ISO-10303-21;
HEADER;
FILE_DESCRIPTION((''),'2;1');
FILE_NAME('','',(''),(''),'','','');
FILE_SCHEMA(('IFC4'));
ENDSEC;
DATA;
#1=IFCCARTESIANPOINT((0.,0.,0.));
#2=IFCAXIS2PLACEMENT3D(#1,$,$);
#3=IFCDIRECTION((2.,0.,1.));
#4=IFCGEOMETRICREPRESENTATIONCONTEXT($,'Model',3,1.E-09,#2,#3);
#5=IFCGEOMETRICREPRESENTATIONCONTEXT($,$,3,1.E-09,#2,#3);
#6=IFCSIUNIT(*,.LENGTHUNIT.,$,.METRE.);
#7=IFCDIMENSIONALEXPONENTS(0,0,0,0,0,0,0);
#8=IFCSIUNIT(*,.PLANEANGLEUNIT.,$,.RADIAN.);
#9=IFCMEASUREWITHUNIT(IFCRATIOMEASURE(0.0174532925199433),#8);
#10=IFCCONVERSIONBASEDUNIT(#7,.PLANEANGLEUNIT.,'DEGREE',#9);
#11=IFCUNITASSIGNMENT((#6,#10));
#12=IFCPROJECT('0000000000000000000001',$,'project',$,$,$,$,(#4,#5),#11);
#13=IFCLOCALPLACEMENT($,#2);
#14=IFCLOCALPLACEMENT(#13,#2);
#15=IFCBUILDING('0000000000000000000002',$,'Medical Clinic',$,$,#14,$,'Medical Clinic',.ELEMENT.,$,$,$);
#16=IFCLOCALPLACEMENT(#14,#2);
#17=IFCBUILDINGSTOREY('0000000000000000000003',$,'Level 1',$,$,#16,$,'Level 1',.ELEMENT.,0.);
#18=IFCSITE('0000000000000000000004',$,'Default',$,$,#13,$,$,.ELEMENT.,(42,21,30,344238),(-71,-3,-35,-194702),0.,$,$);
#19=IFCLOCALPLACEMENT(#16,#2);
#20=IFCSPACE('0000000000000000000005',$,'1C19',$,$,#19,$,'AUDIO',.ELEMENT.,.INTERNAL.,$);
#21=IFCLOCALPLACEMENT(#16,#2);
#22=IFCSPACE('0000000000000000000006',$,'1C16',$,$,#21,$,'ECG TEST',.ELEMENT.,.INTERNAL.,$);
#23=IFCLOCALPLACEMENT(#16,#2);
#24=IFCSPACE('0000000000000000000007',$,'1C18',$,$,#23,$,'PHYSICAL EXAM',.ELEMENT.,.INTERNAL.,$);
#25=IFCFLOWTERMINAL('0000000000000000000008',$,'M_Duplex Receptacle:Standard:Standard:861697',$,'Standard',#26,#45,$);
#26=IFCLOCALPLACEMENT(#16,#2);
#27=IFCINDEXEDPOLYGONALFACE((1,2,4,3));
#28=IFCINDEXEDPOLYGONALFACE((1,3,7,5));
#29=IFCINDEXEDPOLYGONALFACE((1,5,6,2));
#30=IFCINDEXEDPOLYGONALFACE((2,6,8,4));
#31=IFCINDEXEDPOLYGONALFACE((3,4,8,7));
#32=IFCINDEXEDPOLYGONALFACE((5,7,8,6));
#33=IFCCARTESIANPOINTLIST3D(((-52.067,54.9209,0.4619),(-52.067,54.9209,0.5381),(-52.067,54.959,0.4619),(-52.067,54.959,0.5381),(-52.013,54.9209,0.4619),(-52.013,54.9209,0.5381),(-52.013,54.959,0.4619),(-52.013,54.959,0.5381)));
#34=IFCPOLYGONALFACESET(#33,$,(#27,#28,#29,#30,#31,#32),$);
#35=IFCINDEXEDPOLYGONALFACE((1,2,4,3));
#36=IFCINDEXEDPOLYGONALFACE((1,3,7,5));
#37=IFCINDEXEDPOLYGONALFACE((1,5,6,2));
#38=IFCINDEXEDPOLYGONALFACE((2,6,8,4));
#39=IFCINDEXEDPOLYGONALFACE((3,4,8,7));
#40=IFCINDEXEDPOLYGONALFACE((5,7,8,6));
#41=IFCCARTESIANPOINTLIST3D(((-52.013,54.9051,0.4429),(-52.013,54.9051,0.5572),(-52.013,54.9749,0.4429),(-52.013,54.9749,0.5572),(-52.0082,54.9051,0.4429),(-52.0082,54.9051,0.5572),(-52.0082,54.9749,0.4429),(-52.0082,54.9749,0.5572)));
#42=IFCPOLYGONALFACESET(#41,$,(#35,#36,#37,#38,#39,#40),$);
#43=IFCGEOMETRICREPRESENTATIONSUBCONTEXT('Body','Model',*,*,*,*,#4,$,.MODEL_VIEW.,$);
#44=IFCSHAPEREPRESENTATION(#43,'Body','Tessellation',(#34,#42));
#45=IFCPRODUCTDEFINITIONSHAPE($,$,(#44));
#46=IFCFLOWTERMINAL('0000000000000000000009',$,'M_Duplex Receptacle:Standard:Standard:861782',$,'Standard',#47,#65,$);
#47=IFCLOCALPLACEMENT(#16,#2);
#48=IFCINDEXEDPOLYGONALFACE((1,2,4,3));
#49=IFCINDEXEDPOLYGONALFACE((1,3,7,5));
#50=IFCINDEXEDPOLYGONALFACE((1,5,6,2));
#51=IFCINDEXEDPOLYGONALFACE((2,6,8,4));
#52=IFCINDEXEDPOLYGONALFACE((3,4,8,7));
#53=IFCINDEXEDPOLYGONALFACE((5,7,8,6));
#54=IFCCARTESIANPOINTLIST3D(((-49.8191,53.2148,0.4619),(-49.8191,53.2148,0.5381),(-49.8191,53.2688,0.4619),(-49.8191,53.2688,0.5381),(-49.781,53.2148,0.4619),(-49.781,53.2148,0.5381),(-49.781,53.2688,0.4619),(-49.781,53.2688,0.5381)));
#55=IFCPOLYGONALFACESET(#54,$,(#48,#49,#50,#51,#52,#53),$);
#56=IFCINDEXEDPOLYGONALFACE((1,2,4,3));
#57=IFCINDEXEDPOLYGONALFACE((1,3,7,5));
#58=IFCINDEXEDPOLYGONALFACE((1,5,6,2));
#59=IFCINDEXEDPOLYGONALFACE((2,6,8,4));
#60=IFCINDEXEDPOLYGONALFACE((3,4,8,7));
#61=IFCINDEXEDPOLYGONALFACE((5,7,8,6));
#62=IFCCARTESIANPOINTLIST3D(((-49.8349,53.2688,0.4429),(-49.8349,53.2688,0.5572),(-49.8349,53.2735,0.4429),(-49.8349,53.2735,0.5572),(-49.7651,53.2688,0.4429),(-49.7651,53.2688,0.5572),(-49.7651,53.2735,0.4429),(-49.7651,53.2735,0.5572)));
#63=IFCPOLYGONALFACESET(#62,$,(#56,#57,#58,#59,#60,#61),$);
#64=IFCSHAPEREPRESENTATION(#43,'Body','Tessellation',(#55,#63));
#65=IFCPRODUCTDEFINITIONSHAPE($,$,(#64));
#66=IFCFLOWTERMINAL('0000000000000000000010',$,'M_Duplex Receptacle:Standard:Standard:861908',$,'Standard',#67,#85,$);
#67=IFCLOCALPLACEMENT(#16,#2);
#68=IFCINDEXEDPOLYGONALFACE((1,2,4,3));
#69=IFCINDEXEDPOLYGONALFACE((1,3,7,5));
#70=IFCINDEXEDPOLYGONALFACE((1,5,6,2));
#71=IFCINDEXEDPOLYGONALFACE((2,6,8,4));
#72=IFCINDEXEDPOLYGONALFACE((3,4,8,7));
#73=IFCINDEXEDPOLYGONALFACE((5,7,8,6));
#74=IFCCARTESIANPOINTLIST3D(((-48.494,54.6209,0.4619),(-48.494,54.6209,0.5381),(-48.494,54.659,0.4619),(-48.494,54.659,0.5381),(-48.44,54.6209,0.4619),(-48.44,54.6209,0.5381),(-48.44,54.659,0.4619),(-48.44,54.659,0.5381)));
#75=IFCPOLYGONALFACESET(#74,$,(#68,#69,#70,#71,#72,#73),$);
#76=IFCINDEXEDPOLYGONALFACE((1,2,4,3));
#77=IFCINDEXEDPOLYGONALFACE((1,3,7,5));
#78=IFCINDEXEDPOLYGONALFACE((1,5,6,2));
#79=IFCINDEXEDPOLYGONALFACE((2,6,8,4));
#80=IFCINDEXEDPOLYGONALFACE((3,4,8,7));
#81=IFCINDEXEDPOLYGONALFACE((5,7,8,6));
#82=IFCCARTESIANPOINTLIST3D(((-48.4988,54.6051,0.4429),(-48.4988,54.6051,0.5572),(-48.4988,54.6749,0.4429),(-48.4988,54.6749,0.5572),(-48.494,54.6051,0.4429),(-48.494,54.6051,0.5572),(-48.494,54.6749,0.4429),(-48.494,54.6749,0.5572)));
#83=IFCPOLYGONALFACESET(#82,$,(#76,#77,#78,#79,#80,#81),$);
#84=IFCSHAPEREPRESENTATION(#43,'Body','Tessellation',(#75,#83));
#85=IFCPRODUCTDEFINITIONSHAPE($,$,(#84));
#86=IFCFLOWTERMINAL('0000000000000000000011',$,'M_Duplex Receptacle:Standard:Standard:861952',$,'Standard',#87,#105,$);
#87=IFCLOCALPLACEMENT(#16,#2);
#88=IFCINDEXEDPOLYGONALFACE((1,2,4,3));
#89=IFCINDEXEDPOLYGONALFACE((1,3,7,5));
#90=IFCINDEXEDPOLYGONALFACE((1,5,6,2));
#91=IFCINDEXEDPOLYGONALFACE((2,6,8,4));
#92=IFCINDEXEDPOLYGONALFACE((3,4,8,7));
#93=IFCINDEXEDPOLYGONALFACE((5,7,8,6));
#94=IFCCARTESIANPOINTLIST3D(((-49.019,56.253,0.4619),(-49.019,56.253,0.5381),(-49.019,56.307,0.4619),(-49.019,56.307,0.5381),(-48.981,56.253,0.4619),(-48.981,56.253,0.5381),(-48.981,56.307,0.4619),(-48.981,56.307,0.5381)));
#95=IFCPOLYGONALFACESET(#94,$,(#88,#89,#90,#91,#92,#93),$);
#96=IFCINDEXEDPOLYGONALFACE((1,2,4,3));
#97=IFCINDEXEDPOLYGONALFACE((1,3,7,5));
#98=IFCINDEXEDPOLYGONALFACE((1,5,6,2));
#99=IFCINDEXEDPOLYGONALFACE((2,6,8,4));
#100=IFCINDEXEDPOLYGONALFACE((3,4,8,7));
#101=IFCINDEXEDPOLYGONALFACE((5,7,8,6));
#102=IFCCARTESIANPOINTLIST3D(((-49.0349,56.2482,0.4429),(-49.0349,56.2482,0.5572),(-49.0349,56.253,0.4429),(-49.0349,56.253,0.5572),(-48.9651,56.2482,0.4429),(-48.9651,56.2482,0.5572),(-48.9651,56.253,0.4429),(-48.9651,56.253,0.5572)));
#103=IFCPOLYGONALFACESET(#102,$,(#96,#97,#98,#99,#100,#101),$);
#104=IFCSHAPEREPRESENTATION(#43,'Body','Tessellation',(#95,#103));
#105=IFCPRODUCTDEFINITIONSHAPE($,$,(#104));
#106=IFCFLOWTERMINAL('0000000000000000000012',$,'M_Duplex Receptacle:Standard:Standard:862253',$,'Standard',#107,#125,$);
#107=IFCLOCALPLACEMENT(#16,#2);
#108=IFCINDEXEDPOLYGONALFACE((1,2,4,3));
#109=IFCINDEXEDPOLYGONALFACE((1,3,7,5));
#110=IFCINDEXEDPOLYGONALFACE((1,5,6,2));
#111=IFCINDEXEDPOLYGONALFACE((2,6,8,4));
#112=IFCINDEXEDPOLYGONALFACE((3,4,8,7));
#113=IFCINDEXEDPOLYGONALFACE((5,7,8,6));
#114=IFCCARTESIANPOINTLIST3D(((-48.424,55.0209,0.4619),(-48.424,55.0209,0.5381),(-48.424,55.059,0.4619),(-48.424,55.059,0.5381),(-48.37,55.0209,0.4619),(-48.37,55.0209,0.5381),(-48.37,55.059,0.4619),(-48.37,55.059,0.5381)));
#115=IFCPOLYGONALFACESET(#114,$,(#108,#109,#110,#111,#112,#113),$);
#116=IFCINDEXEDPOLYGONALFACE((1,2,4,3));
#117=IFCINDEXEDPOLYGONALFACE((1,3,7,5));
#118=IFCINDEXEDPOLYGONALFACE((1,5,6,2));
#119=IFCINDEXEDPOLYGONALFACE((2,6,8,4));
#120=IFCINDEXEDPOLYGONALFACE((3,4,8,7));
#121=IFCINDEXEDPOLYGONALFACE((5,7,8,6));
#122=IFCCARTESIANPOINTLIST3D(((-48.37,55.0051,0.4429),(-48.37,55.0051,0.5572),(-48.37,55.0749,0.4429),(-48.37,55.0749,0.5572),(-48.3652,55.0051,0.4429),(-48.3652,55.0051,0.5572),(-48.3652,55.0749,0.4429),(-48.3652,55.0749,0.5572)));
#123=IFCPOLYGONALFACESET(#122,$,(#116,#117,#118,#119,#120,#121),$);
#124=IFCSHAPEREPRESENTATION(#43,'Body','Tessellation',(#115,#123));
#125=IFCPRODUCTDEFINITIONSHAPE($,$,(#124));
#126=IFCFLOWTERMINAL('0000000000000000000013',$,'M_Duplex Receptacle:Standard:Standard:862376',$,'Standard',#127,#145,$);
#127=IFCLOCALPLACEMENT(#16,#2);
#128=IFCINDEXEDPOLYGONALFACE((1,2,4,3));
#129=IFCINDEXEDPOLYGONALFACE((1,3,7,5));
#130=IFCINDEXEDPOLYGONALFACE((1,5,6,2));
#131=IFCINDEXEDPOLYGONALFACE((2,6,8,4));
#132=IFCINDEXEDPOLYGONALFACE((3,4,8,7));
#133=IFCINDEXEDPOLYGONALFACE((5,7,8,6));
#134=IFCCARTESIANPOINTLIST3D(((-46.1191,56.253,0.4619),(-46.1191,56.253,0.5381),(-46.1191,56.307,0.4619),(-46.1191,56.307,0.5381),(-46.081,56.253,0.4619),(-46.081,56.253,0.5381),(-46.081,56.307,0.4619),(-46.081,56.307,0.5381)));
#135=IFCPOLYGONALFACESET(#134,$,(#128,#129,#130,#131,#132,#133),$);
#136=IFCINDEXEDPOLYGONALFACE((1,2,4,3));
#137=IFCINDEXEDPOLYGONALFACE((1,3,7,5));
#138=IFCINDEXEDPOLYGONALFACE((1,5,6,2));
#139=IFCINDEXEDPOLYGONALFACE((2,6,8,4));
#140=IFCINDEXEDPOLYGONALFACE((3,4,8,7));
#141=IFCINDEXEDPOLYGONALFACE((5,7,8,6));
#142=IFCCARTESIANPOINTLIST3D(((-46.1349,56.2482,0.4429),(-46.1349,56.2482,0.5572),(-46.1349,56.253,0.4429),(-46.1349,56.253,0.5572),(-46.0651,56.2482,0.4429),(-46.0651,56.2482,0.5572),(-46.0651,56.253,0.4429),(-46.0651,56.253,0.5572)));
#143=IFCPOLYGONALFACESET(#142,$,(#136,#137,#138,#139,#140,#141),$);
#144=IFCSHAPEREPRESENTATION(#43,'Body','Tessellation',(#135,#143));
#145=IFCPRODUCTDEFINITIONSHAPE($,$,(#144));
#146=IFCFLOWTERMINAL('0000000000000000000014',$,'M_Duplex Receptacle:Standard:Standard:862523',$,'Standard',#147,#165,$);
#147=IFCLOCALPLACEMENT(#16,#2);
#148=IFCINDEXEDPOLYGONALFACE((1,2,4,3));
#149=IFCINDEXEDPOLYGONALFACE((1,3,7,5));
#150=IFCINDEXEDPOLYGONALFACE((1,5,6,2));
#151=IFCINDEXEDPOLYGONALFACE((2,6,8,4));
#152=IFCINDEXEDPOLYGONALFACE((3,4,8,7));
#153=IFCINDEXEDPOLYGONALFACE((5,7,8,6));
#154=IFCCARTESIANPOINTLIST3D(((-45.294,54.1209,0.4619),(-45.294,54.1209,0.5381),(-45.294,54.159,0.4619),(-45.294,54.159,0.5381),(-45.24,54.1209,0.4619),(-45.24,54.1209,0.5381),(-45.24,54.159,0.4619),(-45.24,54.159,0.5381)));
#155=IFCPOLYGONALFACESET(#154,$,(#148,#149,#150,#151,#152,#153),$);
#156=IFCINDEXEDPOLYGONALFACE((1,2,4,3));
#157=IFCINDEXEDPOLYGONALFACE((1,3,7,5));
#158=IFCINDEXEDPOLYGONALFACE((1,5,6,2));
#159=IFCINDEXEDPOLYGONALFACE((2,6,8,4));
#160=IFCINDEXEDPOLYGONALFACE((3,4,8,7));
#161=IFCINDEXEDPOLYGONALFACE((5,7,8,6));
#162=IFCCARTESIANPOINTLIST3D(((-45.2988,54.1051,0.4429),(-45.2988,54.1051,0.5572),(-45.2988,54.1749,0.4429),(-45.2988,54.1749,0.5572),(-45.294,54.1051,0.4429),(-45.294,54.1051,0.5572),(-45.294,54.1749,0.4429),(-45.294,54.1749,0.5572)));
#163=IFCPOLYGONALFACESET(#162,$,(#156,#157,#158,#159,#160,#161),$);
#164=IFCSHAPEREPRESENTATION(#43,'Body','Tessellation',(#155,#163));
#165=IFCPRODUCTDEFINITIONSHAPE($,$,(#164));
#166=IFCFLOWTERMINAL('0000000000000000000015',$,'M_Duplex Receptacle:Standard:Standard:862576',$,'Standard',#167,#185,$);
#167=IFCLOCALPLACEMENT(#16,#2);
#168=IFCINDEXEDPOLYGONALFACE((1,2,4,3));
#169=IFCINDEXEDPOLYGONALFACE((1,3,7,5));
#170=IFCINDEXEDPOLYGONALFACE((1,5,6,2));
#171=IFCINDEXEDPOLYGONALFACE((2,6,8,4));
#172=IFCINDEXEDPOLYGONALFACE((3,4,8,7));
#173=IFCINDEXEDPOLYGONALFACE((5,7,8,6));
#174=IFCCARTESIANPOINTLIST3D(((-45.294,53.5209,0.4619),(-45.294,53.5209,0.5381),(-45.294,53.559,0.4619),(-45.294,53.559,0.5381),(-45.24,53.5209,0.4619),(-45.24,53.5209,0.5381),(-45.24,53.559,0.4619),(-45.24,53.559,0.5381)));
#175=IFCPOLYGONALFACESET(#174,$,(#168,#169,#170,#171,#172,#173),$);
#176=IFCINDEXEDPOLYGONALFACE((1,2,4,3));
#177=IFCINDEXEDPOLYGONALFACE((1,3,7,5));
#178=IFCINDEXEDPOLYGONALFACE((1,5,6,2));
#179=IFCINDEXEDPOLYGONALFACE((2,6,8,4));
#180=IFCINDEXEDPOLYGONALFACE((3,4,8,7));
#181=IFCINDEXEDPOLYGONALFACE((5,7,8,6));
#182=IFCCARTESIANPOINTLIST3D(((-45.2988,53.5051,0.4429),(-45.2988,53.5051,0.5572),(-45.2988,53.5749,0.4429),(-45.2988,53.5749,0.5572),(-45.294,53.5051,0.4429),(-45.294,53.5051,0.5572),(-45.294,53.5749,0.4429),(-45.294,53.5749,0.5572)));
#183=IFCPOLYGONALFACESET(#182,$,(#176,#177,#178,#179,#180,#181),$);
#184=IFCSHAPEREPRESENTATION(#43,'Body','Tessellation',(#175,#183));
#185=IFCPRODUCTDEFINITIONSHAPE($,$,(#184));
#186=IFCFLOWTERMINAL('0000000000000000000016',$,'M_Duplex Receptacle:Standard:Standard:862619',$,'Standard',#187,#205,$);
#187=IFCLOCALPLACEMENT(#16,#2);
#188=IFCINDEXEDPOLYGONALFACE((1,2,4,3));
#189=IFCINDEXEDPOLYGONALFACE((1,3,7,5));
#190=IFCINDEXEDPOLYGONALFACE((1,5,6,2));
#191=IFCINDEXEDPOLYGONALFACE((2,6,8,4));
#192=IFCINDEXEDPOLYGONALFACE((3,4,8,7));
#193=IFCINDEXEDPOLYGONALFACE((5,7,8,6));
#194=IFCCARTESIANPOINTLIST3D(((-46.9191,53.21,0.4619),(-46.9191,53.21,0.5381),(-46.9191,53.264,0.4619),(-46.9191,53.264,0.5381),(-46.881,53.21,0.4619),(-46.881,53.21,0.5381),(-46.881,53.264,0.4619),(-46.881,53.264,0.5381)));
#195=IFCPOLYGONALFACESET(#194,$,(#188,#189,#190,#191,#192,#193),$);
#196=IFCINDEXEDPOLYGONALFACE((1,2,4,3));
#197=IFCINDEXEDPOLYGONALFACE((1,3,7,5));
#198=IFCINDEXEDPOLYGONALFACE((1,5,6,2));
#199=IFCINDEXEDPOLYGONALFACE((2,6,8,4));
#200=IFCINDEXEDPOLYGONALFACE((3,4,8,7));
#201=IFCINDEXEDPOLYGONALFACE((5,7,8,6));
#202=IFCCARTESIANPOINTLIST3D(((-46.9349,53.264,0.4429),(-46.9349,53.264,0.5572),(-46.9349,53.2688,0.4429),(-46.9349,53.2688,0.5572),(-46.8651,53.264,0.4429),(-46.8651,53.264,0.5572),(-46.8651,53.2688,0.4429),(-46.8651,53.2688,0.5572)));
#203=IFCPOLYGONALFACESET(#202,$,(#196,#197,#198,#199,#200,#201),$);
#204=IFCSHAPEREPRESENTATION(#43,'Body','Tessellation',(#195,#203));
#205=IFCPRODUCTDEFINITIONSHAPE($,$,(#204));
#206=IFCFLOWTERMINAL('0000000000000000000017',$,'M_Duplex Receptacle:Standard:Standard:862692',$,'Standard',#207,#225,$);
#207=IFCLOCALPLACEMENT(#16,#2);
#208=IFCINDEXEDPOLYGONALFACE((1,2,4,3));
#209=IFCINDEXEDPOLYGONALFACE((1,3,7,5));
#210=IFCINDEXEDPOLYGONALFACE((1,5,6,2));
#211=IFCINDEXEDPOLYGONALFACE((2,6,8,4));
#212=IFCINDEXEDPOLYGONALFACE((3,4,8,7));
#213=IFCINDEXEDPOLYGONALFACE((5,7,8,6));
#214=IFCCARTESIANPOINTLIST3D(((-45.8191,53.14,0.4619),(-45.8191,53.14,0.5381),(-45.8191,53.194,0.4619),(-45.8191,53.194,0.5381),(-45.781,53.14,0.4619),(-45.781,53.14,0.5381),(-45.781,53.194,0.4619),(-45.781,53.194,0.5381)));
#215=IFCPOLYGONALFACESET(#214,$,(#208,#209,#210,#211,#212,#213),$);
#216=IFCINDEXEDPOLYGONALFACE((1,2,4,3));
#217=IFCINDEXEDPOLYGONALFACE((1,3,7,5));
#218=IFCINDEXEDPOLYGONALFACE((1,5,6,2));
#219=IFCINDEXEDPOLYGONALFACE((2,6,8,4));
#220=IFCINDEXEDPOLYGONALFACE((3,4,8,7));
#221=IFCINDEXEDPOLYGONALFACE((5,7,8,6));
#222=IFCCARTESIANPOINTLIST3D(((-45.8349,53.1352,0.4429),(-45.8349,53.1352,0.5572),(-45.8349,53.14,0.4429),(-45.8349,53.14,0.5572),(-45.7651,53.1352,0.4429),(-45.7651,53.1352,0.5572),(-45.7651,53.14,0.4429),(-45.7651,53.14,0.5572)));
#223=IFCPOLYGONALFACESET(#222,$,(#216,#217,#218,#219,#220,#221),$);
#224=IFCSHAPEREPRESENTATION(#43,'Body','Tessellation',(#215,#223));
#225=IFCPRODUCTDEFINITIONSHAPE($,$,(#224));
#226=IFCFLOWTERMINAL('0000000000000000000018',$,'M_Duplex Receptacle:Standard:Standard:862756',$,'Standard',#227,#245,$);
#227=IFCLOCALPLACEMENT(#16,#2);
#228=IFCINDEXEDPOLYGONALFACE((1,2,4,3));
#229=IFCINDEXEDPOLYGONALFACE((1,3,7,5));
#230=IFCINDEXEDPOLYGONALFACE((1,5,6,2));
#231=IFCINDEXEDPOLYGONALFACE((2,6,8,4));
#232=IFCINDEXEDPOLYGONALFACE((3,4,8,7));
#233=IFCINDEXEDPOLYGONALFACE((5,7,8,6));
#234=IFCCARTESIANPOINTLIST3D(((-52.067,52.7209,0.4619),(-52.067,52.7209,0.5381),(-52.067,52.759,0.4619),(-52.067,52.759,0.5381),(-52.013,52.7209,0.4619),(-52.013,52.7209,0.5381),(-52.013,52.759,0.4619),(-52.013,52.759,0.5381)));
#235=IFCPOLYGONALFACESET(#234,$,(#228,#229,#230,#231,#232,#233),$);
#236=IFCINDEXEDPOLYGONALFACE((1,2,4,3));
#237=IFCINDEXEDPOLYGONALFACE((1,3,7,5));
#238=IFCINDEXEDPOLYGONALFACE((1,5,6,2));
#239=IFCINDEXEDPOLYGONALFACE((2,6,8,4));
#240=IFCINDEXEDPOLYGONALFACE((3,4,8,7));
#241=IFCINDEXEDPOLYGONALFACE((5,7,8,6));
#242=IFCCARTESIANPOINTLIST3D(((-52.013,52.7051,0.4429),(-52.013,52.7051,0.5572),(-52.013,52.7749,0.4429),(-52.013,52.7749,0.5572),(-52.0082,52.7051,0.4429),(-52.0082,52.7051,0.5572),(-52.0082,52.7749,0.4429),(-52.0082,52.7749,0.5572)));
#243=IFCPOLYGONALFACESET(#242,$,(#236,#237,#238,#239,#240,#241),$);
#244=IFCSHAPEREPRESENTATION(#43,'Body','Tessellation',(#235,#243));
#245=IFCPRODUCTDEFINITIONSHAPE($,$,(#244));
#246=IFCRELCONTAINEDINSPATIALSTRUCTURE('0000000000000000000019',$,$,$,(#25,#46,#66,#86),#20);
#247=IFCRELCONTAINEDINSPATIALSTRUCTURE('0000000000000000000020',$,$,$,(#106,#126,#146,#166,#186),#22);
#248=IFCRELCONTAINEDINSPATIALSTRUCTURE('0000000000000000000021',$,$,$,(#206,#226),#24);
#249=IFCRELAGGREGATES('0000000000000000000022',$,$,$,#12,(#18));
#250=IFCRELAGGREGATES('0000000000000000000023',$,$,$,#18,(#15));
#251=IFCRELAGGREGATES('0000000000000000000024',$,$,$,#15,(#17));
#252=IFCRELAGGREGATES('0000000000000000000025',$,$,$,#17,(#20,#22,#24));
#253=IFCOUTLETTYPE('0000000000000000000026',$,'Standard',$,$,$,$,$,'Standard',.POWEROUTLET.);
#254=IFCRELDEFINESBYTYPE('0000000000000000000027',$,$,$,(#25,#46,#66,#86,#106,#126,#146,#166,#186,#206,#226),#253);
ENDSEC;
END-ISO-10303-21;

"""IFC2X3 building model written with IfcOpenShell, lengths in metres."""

from ifc_helpers import new_model, entity, si_unit, converted_unit, direction, frame, frame_2d, origin, origin_2d_with_axis, place, context, subcontext, project, spatial, rectangle, extrude, source, transform, mapped, type_object, type_shapes, element, save


model = new_model("IFC2X3")

# Units and contexts
model_context = context("Model", 3, precision=1e-09, world=origin(), true_north=direction((2.0, 0.0, 1.0)))
context_of_model = context(None, 3, precision=1e-09, world=origin(), true_north=direction((2.0, 0.0, 1.0)))
body_context = subcontext(model_context, "Body", "Model", "MODEL_VIEW")
ifc_project = project(units=[si_unit("LENGTHUNIT", "METRE"), converted_unit("PLANEANGLEUNIT", "DEGREE", entity("IfcRatioMeasure", 0.0174532925199433), si_unit("PLANEANGLEUNIT", "RADIAN"), dimensions=[0, 0, 0, 0, 0, 0, 0])], contexts=[model_context, context_of_model])

# Site, building, storey, space
site_placement = place(None, origin())
site = spatial("IfcSite", under=ifc_project, at=site_placement, Name="Default", CompositionType="ELEMENT", RefLatitude=(42, 21, 30, 344238), RefLongitude=(-71, -3, -35, -194702), RefElevation=0.0)
building_placement = place(site_placement, origin())
building = spatial("IfcBuilding", under=site, at=building_placement, Name="Medical Clinic", LongName="Medical Clinic", CompositionType="ELEMENT")
storey_placement = place(building_placement, origin())
storey = spatial("IfcBuildingStorey", under=building, at=storey_placement, Name="Level 1", LongName="Level 1", CompositionType="ELEMENT", Elevation=0.0)
space_1_placement = place(storey_placement, origin())
space_1 = spatial("IfcSpace", under=storey, at=space_1_placement, Name="1C19", LongName="AUDIO", CompositionType="ELEMENT", InteriorOrExteriorSpace="INTERNAL")

# Flow terminals
outlet_type = type_object("IfcOutletType", Name="Standard", ElementType="Standard", PredefinedType="POWEROUTLET")
shared_shape_1 = source(origin(), body_context, "Body", "SweptSolid", [
    extrude(rectangle(XDim=0.0381, YDim=0.0762, at=origin_2d_with_axis()), frame((0.0, 0.0, -0.054), z_axis=(0.0, 0.0, 1.0), x_axis=(-1.0, 0.0, 0.0)), (0.0, 0.0, 1.0), 0.054),
    extrude(rectangle(XDim=0.0698, YDim=0.1143, at=frame_2d((0.0, 0.0), x_axis=(1.0, 0.0))), frame((0.0, 0.0, 0.0), z_axis=(0.0, 0.0, 1.0), x_axis=(-1.0, 0.0, 0.0)), (0.0, 0.0, 1.0), 0.0048),
])
type_shapes(outlet_type, [shared_shape_1])
for number, where, z_axis, x_axis, name in (
    (1, (-52.013, 54.94, 0.5), (1.0, 0.0, 0.0), (0.0, 1.0, 0.0), "M_Duplex Receptacle:Standard:Standard:861697"),
    (2, (-49.8, 53.2688, 0.5), (0.0, 1.0, 0.0), (-1.0, 0.0, 0.0), "M_Duplex Receptacle:Standard:Standard:861782"),
    (3, (-48.494, 54.64, 0.5), (-1.0, 0.0, 0.0), (0.0, -1.0, 0.0), "M_Duplex Receptacle:Standard:Standard:861908"),
    (4, (-49.0, 56.253, 0.5), (0.0, -1.0, 0.0), (1.0, 0.0, 0.0), "M_Duplex Receptacle:Standard:Standard:861952"),
):
    element("IfcFlowTerminal", number, at=place(space_1_placement, frame(where, z_axis=z_axis, x_axis=x_axis)), inside=space_1, type_object=outlet_type, Name=name, ObjectType="Standard", context=body_context, shape_type="MappedRepresentation", body=[
        mapped(shared_shape_1, transform((0.0, 0.0, 0.0), scale=1.0)),
    ])

# Shared definitions
space_2_placement = place(storey_placement, origin())
space_2 = spatial("IfcSpace", under=storey, at=space_2_placement, Name="1C16", LongName="ECG TEST", CompositionType="ELEMENT", InteriorOrExteriorSpace="INTERNAL")

# Flow terminals
for number, where, z_axis, x_axis, name in (
    (5, (-48.37, 55.04, 0.5), (1.0, 0.0, 0.0), (0.0, 1.0, 0.0), "M_Duplex Receptacle:Standard:Standard:862253"),
    (6, (-46.1, 56.253, 0.5), (0.0, -1.0, 0.0), (1.0, 0.0, 0.0), "M_Duplex Receptacle:Standard:Standard:862376"),
    (7, (-45.294, 54.14, 0.5), (-1.0, 0.0, 0.0), (0.0, -1.0, 0.0), "M_Duplex Receptacle:Standard:Standard:862523"),
    (8, (-45.294, 53.54, 0.5), (-1.0, 0.0, 0.0), (0.0, -1.0, 0.0), "M_Duplex Receptacle:Standard:Standard:862576"),
    (9, (-46.9, 53.264, 0.5), (0.0, 1.0, 0.0), (-1.0, 0.0, 0.0), "M_Duplex Receptacle:Standard:Standard:862619"),
):
    element("IfcFlowTerminal", number, at=place(space_2_placement, frame(where, z_axis=z_axis, x_axis=x_axis)), inside=space_2, type_object=outlet_type, Name=name, ObjectType="Standard", context=body_context, shape_type="MappedRepresentation", body=[
        mapped(shared_shape_1, transform((0.0, 0.0, 0.0), scale=1.0)),
    ])

# Shared definitions
space_3_placement = place(storey_placement, origin())
space_3 = spatial("IfcSpace", under=storey, at=space_3_placement, Name="1C18", LongName="PHYSICAL EXAM", CompositionType="ELEMENT", InteriorOrExteriorSpace="INTERNAL")

# Flow terminals
for number, where, z_axis, x_axis, name in (
    (10, (-45.8, 53.14, 0.5), (0.0, -1.0, 0.0), (1.0, 0.0, 0.0), "M_Duplex Receptacle:Standard:Standard:862692"),
    (11, (-52.013, 52.74, 0.5), (1.0, 0.0, 0.0), (0.0, 1.0, 0.0), "M_Duplex Receptacle:Standard:Standard:862756"),
):
    element("IfcFlowTerminal", number, at=place(space_3_placement, frame(where, z_axis=z_axis, x_axis=x_axis)), inside=space_3, type_object=outlet_type, Name=name, ObjectType="Standard", context=body_context, shape_type="MappedRepresentation", body=[
        mapped(shared_shape_1, transform((0.0, 0.0, 0.0), scale=1.0)),
    ])

save(model, "model.ifc")
